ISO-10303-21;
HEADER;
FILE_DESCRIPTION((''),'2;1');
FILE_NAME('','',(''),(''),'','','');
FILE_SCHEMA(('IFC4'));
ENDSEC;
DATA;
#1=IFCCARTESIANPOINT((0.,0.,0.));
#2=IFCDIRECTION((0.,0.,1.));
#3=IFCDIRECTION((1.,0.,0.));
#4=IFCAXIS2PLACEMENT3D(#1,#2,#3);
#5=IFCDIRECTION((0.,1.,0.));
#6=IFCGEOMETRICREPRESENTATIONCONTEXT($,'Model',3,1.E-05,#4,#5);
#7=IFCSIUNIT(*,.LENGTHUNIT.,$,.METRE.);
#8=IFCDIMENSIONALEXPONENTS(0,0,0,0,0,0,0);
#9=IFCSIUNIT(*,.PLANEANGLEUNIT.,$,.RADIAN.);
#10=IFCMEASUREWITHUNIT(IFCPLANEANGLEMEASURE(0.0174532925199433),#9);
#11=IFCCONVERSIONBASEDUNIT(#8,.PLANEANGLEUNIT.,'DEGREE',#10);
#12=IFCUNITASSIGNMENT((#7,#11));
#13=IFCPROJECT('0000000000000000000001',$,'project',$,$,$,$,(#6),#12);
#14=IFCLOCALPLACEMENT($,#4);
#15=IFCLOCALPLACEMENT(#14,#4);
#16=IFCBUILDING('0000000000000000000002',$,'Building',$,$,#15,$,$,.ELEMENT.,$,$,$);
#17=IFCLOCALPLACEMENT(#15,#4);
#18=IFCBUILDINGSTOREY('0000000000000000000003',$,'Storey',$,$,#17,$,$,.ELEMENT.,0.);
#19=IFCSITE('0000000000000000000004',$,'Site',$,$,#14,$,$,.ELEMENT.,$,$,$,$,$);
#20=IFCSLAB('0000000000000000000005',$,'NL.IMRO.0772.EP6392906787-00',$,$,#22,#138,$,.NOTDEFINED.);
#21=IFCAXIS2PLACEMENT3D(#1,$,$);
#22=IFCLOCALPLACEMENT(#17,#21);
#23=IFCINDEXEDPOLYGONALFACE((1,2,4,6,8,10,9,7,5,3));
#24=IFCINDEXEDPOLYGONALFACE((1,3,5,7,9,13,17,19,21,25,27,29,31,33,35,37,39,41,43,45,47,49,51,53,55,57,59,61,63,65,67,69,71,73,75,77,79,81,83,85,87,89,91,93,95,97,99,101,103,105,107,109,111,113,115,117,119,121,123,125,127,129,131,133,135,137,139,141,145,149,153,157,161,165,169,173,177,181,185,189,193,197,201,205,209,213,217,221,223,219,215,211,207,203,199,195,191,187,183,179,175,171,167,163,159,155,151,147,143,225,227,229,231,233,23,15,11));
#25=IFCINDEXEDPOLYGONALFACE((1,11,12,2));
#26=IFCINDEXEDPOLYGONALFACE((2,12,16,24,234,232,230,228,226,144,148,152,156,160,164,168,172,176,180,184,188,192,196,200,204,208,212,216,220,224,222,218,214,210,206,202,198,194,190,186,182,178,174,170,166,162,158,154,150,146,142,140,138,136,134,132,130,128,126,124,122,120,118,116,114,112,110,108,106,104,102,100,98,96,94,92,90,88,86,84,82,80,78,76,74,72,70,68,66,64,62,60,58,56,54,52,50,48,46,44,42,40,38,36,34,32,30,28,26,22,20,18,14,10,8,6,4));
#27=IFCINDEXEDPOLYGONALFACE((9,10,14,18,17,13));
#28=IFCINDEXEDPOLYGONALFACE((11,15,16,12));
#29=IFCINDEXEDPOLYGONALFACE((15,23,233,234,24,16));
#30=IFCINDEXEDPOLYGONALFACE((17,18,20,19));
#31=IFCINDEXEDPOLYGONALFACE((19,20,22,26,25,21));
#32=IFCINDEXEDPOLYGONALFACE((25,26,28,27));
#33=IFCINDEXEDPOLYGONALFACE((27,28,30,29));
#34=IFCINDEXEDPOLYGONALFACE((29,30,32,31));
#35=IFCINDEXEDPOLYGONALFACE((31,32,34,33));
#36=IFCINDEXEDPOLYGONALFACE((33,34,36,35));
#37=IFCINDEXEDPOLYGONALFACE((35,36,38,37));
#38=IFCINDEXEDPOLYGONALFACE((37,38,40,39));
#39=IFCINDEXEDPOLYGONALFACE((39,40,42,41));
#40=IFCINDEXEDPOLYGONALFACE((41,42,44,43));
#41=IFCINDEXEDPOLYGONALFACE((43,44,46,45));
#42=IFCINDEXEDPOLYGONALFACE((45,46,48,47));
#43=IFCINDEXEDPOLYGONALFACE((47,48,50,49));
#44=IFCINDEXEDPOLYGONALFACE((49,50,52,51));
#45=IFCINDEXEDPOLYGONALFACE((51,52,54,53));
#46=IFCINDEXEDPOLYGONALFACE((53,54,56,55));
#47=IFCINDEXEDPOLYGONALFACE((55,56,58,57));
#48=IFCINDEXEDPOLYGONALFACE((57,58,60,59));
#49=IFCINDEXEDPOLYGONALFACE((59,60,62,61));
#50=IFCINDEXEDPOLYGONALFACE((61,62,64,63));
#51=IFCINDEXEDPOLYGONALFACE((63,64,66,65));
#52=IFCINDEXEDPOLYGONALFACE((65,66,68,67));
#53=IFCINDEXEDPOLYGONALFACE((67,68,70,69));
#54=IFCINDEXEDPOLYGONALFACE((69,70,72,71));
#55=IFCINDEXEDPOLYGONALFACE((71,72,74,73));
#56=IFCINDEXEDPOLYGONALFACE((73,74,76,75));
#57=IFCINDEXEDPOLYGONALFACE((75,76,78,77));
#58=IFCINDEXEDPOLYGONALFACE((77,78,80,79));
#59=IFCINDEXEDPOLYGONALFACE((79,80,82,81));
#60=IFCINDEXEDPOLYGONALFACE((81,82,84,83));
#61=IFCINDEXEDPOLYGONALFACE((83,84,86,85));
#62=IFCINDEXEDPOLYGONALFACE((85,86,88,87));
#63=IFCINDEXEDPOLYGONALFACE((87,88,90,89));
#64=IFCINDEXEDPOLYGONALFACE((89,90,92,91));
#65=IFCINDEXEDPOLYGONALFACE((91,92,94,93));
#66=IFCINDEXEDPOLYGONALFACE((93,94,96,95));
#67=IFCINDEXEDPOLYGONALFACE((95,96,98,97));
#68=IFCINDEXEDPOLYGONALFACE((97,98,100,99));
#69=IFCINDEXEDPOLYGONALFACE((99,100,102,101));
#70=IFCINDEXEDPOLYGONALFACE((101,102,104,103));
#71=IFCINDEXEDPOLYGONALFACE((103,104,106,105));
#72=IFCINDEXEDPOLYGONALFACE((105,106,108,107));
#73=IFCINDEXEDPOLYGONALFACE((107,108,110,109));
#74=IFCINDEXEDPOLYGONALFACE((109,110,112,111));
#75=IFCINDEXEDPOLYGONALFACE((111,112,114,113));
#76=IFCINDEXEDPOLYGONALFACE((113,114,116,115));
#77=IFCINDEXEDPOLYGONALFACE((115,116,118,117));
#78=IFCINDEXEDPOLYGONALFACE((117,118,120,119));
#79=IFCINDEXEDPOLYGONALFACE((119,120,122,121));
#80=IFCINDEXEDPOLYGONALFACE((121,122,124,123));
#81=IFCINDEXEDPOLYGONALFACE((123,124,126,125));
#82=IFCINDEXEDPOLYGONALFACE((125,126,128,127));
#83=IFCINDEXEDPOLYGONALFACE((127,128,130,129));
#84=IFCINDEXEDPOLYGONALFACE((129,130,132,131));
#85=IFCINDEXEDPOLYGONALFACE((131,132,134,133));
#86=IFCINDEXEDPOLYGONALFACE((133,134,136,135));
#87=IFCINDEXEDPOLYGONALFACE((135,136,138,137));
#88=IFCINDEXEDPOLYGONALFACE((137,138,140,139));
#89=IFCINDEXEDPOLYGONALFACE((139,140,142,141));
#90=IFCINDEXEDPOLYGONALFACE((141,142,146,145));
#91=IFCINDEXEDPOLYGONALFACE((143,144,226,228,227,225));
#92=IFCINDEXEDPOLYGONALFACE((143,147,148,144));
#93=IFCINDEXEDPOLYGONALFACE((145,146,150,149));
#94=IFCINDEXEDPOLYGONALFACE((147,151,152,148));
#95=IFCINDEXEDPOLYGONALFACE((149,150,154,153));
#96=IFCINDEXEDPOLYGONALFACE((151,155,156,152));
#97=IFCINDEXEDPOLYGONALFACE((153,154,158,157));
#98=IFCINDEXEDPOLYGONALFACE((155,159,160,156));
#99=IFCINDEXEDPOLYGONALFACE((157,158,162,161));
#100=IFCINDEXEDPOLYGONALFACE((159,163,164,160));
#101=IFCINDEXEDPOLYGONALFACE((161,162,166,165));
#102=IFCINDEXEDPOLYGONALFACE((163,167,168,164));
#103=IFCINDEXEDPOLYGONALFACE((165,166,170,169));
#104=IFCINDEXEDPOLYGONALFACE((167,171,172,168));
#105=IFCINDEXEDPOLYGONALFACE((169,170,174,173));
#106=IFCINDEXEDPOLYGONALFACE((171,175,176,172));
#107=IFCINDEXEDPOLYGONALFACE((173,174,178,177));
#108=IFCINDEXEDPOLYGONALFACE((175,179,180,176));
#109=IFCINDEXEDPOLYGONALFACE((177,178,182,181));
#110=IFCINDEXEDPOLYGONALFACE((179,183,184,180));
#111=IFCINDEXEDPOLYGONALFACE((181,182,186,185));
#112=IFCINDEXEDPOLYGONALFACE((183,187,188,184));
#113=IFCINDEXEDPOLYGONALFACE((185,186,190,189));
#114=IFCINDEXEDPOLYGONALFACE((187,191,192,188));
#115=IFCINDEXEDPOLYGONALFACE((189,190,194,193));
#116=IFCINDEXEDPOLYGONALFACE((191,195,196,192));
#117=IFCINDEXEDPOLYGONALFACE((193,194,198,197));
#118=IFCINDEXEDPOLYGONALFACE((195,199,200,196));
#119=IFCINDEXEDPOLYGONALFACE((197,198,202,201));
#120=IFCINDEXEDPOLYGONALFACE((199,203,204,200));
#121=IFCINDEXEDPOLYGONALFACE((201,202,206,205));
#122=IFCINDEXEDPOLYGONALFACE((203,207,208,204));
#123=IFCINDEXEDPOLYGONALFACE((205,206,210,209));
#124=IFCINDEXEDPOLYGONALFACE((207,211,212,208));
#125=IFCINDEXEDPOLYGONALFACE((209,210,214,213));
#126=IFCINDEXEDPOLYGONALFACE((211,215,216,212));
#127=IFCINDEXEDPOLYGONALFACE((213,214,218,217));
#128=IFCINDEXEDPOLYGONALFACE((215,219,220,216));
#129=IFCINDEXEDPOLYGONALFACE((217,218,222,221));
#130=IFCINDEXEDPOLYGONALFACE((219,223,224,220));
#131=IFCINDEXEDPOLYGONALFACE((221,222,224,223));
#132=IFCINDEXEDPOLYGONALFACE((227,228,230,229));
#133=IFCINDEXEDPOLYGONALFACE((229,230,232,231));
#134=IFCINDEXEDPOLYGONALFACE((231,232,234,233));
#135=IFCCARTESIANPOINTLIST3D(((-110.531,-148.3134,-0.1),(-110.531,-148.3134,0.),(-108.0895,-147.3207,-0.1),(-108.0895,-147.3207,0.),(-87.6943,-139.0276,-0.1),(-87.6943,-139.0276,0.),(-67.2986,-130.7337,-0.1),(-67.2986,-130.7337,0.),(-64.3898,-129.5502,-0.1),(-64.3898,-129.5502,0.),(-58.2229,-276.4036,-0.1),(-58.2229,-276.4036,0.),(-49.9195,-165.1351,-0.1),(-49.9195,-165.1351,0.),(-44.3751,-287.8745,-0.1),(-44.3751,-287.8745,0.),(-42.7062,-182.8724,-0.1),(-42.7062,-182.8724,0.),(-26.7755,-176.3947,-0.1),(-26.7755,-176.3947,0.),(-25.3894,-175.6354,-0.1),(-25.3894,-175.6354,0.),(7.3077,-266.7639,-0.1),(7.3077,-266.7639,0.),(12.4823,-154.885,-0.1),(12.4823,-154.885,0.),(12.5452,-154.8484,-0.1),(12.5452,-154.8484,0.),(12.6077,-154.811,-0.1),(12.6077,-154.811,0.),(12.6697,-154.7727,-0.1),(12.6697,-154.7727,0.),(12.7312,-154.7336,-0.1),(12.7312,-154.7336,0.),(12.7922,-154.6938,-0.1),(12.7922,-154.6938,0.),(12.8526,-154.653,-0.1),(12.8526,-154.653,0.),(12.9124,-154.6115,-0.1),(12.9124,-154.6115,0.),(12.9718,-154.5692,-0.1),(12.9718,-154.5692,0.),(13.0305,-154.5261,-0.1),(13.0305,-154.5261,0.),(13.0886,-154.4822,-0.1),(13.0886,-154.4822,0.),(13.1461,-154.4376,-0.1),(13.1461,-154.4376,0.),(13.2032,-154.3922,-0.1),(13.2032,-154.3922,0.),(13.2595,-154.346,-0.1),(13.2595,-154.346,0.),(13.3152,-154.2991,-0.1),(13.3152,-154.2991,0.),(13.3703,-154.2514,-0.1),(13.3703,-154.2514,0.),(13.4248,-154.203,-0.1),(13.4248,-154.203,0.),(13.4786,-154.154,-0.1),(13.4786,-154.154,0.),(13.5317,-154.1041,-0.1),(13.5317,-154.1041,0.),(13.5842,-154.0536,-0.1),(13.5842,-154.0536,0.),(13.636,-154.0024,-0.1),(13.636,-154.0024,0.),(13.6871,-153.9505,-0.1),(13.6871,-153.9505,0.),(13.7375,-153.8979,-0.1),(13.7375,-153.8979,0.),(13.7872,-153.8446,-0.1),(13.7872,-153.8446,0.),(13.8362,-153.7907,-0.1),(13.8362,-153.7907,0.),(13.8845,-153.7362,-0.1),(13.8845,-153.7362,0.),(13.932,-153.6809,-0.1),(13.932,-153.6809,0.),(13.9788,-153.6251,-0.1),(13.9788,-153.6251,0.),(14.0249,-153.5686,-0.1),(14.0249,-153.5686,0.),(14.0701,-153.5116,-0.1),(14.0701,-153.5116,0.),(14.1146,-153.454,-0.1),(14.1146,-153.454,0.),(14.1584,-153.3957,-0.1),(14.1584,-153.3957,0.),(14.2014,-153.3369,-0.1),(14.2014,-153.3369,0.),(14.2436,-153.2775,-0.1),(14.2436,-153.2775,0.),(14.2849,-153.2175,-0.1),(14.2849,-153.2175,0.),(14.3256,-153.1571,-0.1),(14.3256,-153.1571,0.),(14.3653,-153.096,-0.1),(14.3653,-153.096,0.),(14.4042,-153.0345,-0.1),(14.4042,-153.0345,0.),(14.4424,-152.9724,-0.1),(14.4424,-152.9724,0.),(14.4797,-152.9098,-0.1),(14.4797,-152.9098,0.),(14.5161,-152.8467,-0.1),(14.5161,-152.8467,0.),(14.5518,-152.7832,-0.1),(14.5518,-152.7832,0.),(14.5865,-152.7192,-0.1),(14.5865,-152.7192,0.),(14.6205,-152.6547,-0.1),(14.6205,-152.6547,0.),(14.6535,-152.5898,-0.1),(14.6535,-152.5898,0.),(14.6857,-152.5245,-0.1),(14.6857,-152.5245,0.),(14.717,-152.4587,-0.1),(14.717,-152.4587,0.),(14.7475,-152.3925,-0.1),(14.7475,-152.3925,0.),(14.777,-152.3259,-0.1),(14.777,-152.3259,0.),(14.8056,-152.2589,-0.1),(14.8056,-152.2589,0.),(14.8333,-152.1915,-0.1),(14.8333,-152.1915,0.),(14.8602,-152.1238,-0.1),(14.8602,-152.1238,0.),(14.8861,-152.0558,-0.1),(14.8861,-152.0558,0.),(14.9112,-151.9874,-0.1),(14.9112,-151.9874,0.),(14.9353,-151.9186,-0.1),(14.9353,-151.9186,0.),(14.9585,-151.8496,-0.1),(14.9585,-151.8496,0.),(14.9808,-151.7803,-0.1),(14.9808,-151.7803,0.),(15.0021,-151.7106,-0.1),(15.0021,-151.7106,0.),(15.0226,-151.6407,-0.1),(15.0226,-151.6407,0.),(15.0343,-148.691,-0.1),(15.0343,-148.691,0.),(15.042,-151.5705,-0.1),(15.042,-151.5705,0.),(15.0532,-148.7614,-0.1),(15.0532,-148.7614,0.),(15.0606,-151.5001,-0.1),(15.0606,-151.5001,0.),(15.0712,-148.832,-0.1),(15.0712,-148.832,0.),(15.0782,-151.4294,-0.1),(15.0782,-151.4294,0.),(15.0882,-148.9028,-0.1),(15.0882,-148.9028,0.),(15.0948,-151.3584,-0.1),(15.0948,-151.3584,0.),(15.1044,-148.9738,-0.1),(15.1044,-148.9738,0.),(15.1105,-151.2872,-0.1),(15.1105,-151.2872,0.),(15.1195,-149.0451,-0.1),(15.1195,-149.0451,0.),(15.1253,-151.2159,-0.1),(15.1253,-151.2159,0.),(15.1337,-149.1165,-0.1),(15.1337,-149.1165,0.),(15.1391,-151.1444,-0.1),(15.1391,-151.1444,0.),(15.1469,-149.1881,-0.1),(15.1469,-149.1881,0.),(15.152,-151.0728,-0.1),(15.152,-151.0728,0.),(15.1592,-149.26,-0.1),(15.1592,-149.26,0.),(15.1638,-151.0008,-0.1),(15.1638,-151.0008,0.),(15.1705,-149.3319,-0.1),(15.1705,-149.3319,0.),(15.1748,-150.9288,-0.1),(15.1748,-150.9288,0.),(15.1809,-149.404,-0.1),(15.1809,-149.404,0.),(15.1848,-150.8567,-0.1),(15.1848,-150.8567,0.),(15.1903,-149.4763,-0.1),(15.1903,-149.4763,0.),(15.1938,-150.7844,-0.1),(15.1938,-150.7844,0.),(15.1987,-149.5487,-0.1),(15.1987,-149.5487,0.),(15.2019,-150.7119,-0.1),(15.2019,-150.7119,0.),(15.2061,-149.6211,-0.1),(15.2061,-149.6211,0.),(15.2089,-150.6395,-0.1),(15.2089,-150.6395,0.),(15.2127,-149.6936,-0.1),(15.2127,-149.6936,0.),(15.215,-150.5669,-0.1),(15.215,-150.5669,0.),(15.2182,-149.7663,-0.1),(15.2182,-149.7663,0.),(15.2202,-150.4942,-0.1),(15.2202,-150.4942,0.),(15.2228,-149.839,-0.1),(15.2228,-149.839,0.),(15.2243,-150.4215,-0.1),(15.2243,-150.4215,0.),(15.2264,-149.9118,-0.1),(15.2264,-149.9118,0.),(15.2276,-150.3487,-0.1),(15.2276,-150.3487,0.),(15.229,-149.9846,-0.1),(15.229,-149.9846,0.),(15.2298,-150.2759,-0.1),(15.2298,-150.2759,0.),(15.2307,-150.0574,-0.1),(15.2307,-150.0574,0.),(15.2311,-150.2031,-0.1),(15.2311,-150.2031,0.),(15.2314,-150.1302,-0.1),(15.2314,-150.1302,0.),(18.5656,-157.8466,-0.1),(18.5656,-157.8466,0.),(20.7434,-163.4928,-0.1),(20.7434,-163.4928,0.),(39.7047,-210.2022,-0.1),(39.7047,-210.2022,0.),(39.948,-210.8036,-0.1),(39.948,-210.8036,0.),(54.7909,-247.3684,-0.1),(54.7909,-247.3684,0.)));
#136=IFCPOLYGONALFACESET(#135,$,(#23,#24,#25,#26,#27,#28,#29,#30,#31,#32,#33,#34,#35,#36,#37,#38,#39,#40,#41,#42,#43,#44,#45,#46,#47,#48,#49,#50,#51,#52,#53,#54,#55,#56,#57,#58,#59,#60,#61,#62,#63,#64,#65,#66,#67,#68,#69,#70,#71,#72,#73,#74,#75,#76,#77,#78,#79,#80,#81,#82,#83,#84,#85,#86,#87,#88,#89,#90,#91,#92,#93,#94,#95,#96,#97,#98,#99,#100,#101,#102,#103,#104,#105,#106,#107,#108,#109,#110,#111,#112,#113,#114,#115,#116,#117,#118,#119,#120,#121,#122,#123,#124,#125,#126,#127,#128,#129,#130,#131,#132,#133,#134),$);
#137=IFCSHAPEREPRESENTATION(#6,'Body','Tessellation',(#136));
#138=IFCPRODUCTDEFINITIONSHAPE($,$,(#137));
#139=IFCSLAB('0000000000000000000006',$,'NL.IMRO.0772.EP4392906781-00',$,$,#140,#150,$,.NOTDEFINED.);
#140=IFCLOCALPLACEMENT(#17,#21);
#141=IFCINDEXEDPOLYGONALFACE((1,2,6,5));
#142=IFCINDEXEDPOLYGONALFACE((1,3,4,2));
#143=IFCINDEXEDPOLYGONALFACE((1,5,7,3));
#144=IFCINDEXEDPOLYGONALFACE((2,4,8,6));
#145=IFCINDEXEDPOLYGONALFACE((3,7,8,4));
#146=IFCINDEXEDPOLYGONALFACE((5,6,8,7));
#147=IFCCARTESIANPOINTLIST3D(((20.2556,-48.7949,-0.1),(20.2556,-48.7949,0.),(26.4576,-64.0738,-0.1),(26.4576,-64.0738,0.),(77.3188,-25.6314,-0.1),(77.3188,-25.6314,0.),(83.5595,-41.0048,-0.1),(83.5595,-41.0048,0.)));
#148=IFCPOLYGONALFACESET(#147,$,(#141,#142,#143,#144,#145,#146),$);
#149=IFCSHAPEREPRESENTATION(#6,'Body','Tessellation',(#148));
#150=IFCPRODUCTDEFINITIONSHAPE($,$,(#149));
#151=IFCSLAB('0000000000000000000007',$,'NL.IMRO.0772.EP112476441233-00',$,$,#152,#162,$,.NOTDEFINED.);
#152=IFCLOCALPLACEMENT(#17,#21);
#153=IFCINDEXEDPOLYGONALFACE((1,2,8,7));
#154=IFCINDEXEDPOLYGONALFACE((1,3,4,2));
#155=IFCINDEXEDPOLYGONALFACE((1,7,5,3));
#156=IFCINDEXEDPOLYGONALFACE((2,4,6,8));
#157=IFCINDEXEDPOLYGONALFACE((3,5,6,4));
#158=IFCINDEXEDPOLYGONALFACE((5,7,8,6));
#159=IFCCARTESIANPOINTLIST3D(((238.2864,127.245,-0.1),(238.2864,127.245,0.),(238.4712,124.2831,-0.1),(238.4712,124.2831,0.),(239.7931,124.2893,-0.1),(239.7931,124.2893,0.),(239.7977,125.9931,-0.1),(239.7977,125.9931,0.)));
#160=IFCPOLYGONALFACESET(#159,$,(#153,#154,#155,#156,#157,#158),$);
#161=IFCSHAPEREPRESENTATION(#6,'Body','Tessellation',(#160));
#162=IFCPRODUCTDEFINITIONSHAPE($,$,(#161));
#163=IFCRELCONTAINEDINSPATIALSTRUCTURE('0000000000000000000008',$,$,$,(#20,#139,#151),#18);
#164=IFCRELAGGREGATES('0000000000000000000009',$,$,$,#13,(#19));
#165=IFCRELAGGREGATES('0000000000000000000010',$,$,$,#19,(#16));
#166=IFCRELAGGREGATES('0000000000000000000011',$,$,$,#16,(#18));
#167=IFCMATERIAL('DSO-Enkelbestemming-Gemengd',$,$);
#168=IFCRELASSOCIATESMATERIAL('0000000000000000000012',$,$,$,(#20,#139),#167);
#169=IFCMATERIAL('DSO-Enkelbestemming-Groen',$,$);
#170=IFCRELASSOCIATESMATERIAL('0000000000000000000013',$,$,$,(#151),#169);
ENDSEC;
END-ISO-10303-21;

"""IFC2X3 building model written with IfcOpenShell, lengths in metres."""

from ifc_helpers import new_model, entity, si_unit, converted_unit, direction, frame, origin_with_axes, place, context, project, spatial, polyline, outline, extrude, material, element, save


model = new_model("IFC2X3")

# Units and contexts
model_context = context("Model", 3, precision=1e-05, world=origin_with_axes(), true_north=direction((0.0, 1.0, 0.0)))
ifc_project = project(units=[si_unit("LENGTHUNIT", "METRE"), converted_unit("PLANEANGLEUNIT", "DEGREE", entity("IfcPlaneAngleMeasure", 0.0174532925199433), si_unit("PLANEANGLEUNIT", "RADIAN"), dimensions=[0, 0, 0, 0, 0, 0, 0])], contexts=[model_context])

# Site, building, storey
site_placement = place(None, origin_with_axes())
site = spatial("IfcSite", under=ifc_project, at=site_placement, Name="Site", CompositionType="ELEMENT")
building_placement = place(site_placement, origin_with_axes())
building = spatial("IfcBuilding", under=site, at=building_placement, Name="Building", CompositionType="ELEMENT")
storey_placement = place(building_placement, origin_with_axes())
storey = spatial("IfcBuildingStorey", under=building, at=storey_placement, Name="Storey", CompositionType="ELEMENT", Elevation=0.0)

# Slabs
ifc_material_1 = material(Name="DSO-Enkelbestemming-Gemengd")
slab_1_placement = place(storey_placement, frame((0.0, 0.0, -0.1), z_axis=(0.0, 0.0, 1.0), x_axis=(1.0, 0.0, 0.0)))
element("IfcSlab", 1, at=slab_1_placement, inside=storey, material=ifc_material_1, Name="NL.IMRO.0772.EP6392906787-00", PredefinedType="NOTDEFINED", context=model_context, shape_type="SweptSolid", body=[
    extrude(outline(polyline([(-110.531, -148.3134), (-108.0895, -147.3207), (-87.6943, -139.0276), (-67.2986, -130.7337), (-64.3898, -129.5502), (-49.9195, -165.1351), (-42.7062, -182.8724), (-26.7755, -176.3947), (-25.3894, -175.6354), (12.4823, -154.885), (12.5452, -154.8484), (12.6077, -154.811), (12.6697, -154.7727), (12.7312, -154.7336), (12.7922, -154.6938), (12.8526, -154.653), (12.9124, -154.6115), (12.9718, -154.5692), (13.0305, -154.5261), (13.0886, -154.4822), (13.1461, -154.4376), (13.2032, -154.3922), (13.2595, -154.346), (13.3152, -154.2991), (13.3703, -154.2514), (13.4248, -154.203), (13.4786, -154.154), (13.5317, -154.1041), (13.5842, -154.0536), (13.636, -154.0024), (13.6871, -153.9505), (13.7375, -153.8979), (13.7872, -153.8446), (13.8362, -153.7907), (13.8845, -153.7362), (13.932, -153.6809), (13.9788, -153.6251), (14.0249, -153.5686), (14.0701, -153.5116), (14.1146, -153.454), (14.1584, -153.3957), (14.2014, -153.3369), (14.2436, -153.2775), (14.2849, -153.2175), (14.3256, -153.1571), (14.3653, -153.096), (14.4042, -153.0345), (14.4424, -152.9724), (14.4797, -152.9098), (14.5161, -152.8467), (14.5518, -152.7832), (14.5865, -152.7192), (14.6205, -152.6547), (14.6535, -152.5898), (14.6857, -152.5245), (14.717, -152.4587), (14.7475, -152.3925), (14.777, -152.3259), (14.8056, -152.2589), (14.8333, -152.1915), (14.8602, -152.1238), (14.8861, -152.0558), (14.9112, -151.9874), (14.9353, -151.9186), (14.9585, -151.8496), (14.9808, -151.7803), (15.0021, -151.7106), (15.0226, -151.6407), (15.042, -151.5705), (15.0606, -151.5001), (15.0782, -151.4294), (15.0948, -151.3584), (15.1105, -151.2872), (15.1253, -151.2159), (15.1391, -151.1444), (15.152, -151.0728), (15.1638, -151.0008), (15.1748, -150.9288), (15.1848, -150.8567), (15.1938, -150.7844), (15.2019, -150.7119), (15.2089, -150.6395), (15.215, -150.5669), (15.2202, -150.4942), (15.2243, -150.4215), (15.2276, -150.3487), (15.2298, -150.2759), (15.2311, -150.2031), (15.2314, -150.1302), (15.2307, -150.0574), (15.229, -149.9846), (15.2264, -149.9118), (15.2228, -149.839), (15.2182, -149.7663), (15.2127, -149.6936), (15.2061, -149.6211), (15.1987, -149.5487), (15.1903, -149.4763), (15.1809, -149.404), (15.1705, -149.3319), (15.1592, -149.26), (15.1469, -149.1881), (15.1337, -149.1165), (15.1195, -149.0451), (15.1044, -148.9738), (15.0882, -148.9028), (15.0712, -148.832), (15.0532, -148.7614), (15.0343, -148.691), (18.5656, -157.8466), (20.7434, -163.4928), (39.7047, -210.2022), (39.948, -210.8036), (54.7909, -247.3684), (7.3077, -266.7639), (-44.3751, -287.8745), (-58.2229, -276.4036), (-110.531, -148.3134)])), origin_with_axes(), (0.0, 0.0, 1.0), 0.1),
])
ifc_material_2 = material(Name="DSO-Enkelbestemming-Groen")
slab_2_placement = place(storey_placement, frame((0.0, 0.0, -0.1), z_axis=(0.0, 0.0, 1.0), x_axis=(1.0, 0.0, 0.0)))
element("IfcSlab", 2, at=slab_2_placement, inside=storey, material=ifc_material_1, Name="NL.IMRO.0772.EP4392906781-00", PredefinedType="NOTDEFINED", context=model_context, shape_type="SweptSolid", body=[
    extrude(outline(polyline([(77.3188, -25.6314), (83.5595, -41.0048), (26.4576, -64.0738), (20.2556, -48.7949), (77.3188, -25.6314)])), origin_with_axes(), (0.0, 0.0, 1.0), 0.1),
])
slab_3_placement = place(storey_placement, frame((0.0, 0.0, -0.1), z_axis=(0.0, 0.0, 1.0), x_axis=(1.0, 0.0, 0.0)))
element("IfcSlab", 3, at=slab_3_placement, inside=storey, material=ifc_material_2, Name="NL.IMRO.0772.EP112476441233-00", PredefinedType="NOTDEFINED", context=model_context, shape_type="SweptSolid", body=[
    extrude(outline(polyline([(239.7931, 124.2893), (238.4712, 124.2831), (238.2864, 127.245), (239.7977, 125.9931), (239.7931, 124.2893)])), origin_with_axes(), (0.0, 0.0, 1.0), 0.1),
])

save(model, "model.ifc")
